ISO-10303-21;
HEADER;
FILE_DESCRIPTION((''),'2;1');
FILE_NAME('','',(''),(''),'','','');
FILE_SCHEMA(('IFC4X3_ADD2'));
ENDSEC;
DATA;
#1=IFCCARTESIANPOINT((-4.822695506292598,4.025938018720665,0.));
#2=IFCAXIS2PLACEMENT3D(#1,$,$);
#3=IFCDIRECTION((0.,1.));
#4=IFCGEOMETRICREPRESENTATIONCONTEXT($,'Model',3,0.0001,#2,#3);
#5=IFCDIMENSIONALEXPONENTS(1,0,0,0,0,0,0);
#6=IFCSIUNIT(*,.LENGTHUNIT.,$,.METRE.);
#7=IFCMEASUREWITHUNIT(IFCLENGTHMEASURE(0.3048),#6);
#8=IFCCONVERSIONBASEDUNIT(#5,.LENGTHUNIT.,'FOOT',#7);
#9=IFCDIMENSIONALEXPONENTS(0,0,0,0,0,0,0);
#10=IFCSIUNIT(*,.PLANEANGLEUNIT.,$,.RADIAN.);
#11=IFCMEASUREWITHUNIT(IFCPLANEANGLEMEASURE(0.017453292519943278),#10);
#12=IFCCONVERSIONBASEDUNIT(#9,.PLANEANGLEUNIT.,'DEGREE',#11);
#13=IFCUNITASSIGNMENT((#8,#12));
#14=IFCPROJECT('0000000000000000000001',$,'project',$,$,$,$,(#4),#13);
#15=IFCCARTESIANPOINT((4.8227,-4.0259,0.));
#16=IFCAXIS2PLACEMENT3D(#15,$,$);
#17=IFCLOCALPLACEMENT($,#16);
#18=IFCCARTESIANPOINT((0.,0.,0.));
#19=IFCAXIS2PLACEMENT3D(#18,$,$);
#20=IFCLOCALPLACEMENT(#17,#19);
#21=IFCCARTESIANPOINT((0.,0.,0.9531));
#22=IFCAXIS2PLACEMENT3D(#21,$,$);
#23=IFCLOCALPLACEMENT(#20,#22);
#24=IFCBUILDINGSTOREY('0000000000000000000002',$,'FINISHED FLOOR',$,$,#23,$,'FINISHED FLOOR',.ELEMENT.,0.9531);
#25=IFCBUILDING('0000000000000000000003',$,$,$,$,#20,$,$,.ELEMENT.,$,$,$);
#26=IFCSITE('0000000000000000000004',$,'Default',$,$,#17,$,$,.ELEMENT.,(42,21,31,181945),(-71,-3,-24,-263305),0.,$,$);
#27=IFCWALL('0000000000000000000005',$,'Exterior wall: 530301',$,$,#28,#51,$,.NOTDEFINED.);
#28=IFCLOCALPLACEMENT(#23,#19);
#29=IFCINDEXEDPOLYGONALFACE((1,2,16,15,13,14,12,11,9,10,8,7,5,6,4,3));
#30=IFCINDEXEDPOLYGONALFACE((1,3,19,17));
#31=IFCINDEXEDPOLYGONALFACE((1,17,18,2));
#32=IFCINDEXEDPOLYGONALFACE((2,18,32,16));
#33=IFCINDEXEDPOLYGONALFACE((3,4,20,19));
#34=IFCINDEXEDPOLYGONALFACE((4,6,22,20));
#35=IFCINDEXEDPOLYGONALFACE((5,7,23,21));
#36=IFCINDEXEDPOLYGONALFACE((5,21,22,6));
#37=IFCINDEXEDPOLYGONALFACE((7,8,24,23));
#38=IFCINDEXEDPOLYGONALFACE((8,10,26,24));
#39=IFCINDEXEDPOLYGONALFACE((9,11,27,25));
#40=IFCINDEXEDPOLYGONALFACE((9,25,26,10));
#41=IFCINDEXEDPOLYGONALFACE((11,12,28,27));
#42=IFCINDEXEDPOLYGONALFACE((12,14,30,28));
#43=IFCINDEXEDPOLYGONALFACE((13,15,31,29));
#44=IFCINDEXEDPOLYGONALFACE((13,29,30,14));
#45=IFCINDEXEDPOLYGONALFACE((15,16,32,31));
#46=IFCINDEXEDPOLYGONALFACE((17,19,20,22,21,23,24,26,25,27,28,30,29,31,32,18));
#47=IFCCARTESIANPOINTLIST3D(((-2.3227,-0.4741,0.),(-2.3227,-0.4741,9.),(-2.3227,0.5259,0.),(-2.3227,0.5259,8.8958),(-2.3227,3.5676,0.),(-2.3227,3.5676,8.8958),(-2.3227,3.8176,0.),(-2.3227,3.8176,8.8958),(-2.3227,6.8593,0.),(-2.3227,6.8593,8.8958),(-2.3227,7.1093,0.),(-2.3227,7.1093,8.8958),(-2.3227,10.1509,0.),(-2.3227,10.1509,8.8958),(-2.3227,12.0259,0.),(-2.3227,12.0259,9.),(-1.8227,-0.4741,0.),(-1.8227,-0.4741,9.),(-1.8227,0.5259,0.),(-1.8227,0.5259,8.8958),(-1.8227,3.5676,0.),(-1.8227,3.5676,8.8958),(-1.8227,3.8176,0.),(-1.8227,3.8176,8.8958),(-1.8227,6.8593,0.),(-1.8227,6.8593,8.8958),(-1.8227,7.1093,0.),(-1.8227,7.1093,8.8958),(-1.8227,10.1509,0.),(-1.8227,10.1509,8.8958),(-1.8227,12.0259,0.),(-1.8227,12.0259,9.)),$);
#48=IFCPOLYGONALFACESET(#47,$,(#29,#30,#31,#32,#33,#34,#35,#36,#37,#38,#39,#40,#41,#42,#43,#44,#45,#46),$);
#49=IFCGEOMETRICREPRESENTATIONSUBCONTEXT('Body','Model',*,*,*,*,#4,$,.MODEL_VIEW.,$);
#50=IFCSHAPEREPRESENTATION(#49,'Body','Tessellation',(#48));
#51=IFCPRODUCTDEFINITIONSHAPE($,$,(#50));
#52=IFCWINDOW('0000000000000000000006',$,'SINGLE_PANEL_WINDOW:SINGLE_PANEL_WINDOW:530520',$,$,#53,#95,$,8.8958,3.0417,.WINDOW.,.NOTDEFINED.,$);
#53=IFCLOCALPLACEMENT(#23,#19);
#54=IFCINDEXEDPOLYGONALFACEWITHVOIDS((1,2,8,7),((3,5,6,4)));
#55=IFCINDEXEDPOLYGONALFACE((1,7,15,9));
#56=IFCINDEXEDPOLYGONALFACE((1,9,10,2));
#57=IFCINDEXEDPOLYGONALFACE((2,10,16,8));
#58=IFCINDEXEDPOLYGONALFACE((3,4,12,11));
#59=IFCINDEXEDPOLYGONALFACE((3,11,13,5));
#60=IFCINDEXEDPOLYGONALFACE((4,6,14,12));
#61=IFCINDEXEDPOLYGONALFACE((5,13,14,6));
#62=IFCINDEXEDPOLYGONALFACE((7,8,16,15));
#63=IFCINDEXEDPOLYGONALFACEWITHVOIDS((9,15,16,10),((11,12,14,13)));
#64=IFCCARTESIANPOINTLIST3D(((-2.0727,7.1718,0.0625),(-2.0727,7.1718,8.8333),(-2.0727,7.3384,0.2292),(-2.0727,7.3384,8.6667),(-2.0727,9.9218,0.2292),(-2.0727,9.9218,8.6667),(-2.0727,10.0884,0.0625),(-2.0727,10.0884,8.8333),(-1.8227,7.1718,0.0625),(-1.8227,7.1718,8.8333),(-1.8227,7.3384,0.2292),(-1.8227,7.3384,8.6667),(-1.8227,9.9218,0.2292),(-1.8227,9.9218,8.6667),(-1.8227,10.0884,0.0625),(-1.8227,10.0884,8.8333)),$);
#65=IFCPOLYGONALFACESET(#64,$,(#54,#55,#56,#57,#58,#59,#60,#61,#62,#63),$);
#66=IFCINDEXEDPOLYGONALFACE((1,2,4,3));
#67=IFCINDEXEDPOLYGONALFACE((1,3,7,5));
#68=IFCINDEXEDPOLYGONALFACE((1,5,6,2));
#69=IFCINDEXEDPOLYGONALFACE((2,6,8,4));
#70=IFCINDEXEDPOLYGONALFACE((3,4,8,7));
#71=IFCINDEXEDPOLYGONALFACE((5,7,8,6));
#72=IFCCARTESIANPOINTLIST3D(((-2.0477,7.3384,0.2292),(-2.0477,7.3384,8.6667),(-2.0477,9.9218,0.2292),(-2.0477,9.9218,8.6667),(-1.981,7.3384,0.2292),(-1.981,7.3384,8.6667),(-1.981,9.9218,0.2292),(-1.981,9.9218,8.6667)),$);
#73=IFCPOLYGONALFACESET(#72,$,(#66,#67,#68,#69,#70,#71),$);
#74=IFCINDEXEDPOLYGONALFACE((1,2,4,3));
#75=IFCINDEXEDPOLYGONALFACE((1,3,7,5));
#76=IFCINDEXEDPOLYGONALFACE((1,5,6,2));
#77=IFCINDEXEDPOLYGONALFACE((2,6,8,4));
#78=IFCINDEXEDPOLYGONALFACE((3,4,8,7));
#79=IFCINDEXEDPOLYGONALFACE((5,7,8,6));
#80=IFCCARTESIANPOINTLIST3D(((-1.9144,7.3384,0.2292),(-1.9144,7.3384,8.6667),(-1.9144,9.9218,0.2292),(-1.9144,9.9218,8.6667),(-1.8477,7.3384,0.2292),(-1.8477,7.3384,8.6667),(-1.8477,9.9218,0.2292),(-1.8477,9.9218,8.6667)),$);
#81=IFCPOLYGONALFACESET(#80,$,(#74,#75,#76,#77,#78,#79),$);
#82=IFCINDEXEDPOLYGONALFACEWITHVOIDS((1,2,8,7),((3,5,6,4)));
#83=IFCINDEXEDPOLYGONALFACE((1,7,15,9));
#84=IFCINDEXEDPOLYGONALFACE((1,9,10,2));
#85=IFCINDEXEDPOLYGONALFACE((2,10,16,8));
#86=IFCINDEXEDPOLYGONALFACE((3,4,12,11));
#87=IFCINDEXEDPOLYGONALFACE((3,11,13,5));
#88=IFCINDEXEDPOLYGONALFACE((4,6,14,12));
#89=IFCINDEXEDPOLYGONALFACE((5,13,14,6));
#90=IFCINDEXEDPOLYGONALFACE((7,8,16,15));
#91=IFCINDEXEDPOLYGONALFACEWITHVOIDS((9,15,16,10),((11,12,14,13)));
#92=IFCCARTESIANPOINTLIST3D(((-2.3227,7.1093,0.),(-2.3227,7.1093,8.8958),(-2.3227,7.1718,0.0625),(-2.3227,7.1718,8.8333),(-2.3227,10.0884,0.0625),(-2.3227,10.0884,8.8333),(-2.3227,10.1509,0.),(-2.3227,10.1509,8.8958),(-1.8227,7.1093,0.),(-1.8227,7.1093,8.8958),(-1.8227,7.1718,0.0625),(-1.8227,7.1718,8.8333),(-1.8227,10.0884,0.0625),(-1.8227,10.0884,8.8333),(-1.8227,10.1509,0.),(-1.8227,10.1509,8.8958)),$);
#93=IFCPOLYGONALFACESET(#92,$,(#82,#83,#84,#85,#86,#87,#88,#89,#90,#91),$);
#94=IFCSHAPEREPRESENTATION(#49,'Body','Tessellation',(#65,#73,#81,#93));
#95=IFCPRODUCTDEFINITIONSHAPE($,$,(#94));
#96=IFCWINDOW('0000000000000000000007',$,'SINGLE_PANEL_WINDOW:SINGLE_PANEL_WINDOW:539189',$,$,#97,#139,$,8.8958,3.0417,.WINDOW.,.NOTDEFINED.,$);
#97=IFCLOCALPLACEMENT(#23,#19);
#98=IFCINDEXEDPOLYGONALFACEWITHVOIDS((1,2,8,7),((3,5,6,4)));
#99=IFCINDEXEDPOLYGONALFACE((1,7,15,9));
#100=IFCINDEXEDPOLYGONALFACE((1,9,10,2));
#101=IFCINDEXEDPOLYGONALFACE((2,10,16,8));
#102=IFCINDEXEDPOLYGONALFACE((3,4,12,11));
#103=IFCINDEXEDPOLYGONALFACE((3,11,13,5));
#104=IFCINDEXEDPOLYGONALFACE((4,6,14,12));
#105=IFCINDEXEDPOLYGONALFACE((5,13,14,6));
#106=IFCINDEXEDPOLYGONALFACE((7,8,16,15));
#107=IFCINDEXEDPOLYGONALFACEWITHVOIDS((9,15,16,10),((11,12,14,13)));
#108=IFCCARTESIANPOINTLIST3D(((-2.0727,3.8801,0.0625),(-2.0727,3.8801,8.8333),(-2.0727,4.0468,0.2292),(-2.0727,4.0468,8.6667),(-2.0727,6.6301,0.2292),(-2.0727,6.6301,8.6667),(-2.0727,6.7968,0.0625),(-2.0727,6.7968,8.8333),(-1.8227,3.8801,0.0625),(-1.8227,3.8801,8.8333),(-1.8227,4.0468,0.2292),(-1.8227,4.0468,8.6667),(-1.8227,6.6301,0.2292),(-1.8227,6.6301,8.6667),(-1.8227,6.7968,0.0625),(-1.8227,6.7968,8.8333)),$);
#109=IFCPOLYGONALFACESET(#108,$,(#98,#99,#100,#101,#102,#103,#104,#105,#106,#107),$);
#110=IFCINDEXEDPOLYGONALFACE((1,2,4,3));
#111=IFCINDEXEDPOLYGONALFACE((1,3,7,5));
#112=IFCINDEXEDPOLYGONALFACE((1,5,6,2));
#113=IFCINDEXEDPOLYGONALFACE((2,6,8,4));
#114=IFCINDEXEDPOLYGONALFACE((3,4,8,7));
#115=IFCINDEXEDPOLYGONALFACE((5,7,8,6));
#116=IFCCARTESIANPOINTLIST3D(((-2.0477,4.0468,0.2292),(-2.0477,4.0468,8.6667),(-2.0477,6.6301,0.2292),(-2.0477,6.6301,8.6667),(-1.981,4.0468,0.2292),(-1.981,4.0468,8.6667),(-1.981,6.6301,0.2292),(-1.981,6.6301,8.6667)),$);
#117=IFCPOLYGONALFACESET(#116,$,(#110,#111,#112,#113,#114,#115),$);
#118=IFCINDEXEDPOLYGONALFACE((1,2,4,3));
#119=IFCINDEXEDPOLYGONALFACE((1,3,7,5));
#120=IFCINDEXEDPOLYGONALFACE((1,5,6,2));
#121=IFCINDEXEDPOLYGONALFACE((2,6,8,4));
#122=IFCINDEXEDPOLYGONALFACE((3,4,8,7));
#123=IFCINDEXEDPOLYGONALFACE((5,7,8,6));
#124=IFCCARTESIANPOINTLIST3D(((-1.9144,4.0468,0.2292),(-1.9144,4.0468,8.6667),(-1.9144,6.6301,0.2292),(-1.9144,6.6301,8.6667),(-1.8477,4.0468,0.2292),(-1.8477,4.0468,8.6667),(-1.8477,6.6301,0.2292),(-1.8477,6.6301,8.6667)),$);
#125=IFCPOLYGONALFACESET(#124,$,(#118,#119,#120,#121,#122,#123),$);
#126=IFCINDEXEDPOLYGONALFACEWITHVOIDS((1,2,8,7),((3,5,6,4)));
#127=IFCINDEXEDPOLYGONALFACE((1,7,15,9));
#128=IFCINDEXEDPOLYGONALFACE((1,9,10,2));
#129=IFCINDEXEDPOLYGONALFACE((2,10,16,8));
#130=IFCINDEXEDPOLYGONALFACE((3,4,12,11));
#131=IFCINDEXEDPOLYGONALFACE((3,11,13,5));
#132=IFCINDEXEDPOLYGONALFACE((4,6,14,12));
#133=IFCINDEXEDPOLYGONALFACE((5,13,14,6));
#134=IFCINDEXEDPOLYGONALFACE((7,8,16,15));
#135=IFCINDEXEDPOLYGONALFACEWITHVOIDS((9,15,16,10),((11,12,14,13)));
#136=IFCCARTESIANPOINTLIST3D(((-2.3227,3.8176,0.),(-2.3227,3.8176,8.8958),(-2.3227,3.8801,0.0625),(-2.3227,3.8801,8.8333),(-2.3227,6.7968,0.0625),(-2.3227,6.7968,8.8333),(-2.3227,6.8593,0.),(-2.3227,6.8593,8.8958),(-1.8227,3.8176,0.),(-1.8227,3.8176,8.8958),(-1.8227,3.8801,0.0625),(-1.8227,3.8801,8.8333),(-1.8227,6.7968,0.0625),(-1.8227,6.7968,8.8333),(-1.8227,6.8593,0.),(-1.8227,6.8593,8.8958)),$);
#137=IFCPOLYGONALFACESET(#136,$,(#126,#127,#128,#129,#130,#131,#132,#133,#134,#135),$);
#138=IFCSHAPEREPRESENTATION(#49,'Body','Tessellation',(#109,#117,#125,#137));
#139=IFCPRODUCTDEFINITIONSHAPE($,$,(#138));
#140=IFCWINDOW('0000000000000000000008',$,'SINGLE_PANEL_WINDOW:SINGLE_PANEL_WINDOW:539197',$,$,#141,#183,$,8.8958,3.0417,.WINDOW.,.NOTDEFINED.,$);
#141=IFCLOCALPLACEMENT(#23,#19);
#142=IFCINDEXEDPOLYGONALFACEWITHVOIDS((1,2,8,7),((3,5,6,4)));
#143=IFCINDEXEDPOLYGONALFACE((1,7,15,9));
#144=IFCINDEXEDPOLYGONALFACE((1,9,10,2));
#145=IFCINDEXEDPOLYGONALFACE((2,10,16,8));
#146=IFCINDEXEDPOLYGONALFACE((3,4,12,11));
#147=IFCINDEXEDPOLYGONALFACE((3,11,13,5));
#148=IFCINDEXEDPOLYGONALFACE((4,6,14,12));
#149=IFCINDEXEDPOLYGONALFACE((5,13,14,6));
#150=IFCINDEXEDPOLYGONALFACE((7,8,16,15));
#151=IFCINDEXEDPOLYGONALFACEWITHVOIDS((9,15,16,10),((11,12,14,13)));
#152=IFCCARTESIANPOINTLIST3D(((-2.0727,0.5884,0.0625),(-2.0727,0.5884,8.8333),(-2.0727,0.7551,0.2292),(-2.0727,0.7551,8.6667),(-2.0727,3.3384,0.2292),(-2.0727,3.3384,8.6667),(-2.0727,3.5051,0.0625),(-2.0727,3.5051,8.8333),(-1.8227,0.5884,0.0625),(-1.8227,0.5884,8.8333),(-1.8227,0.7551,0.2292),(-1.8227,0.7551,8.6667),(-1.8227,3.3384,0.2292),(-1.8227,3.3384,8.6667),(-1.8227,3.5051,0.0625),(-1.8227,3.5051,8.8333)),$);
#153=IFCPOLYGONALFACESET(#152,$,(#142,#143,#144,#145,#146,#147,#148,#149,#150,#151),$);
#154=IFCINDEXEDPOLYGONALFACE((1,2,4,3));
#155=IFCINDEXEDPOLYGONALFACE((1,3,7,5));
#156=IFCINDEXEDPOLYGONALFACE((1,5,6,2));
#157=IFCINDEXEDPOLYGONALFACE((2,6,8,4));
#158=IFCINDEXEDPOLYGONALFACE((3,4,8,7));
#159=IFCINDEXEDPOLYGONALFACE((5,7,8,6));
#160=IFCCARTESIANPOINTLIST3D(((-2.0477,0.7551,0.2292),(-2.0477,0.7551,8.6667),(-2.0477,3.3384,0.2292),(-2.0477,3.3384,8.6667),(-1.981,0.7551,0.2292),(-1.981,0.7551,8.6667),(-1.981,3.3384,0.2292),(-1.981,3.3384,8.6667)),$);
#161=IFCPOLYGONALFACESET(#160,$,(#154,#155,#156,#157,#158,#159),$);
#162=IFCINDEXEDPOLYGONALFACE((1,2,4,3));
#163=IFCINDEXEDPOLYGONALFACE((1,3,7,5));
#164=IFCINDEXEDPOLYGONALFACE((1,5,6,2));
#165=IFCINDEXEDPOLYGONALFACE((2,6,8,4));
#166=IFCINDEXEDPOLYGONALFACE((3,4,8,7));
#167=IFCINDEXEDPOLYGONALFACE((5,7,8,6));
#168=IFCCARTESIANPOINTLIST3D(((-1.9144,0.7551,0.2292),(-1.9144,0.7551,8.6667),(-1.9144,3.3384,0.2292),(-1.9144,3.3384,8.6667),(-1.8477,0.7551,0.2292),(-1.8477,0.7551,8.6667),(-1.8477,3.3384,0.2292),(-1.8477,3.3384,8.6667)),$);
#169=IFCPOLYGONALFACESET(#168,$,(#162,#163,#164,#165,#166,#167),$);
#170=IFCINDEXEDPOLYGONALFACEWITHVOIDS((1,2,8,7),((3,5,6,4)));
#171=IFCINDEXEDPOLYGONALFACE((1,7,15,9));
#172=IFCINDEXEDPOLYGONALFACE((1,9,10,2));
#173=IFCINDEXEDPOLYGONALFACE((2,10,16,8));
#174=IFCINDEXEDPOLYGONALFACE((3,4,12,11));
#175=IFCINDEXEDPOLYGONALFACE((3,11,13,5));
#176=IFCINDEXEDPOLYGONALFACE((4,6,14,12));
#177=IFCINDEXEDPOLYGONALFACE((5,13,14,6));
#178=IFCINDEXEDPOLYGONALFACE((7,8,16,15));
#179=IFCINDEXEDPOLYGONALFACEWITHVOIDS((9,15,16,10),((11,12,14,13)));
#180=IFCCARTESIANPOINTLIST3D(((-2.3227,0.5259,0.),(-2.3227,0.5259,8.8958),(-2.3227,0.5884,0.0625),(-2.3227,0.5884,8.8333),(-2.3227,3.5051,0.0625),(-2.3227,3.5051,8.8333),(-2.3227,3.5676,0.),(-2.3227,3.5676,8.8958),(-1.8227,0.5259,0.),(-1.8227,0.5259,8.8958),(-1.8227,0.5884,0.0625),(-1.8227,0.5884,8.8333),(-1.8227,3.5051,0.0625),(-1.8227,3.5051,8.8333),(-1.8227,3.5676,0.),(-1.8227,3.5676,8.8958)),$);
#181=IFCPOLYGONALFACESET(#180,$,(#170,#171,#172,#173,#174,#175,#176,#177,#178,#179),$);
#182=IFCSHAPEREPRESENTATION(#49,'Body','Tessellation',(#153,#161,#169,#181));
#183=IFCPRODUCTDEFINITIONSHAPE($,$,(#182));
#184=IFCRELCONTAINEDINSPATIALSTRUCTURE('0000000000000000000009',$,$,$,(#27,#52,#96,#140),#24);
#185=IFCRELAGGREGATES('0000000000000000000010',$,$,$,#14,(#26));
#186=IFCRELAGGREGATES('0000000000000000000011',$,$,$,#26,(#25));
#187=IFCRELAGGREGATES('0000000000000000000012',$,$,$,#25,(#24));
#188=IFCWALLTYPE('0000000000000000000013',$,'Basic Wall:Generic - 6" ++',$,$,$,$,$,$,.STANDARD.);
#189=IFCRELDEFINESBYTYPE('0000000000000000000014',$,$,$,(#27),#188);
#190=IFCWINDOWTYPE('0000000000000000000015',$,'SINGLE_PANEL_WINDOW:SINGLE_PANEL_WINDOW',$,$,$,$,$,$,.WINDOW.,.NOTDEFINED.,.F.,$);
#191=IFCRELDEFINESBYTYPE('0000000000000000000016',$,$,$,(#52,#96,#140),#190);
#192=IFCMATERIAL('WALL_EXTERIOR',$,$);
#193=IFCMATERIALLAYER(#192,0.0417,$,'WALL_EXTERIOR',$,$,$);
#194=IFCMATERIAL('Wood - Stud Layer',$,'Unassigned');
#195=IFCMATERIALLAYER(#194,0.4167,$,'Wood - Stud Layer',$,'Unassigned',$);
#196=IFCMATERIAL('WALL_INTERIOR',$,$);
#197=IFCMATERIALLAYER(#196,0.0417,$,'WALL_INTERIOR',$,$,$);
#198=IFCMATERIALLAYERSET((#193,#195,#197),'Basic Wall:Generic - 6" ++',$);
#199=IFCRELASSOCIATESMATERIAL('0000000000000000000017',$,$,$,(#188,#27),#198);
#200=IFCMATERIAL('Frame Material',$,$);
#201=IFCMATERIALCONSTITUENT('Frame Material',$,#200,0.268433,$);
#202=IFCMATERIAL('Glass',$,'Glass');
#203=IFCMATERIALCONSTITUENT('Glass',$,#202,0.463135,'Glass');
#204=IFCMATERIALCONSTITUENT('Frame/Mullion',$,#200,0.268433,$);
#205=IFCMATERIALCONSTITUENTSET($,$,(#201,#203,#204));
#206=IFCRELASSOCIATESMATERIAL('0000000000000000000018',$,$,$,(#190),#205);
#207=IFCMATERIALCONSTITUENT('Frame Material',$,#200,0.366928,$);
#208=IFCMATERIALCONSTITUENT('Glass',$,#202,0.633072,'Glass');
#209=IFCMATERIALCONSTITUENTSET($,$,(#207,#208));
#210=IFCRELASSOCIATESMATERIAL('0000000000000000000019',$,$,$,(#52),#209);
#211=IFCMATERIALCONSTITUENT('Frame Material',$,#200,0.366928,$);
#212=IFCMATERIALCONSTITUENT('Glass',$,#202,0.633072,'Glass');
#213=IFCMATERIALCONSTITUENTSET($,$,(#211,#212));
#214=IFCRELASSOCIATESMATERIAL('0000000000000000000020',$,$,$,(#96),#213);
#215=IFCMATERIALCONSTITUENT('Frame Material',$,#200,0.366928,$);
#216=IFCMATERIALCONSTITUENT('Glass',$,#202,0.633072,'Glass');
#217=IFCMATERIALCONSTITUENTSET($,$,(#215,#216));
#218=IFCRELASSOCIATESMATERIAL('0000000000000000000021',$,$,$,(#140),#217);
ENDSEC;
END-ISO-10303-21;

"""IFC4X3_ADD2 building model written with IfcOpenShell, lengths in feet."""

from ifc_helpers import new_model, entity, si_unit, converted_unit, direction, frame, frame_2d, origin, origin_2d_with_axis, place, context, subcontext, project, spatial, polyline, rectangle, outline, extrude, source, transform, mapped, material, layer, layer_set, constituent, constituent_set, type_object, type_shapes, element, fill, save


model = new_model("IFC4X3_ADD2")

# Units and contexts
model_context = context("Model", 3, precision=0.0001, world=frame((-4.822695506292598, 4.025938018720665, 0.0)), true_north=direction((0.0, 1.0)))
body_context = subcontext(model_context, "Body", "Model", "MODEL_VIEW")
ifc_project = project(units=[converted_unit("LENGTHUNIT", "FOOT", entity("IfcLengthMeasure", 0.3048), si_unit("LENGTHUNIT", "METRE"), dimensions=[1, 0, 0, 0, 0, 0, 0]), converted_unit("PLANEANGLEUNIT", "DEGREE", entity("IfcPlaneAngleMeasure", 0.017453292519943278), si_unit("PLANEANGLEUNIT", "RADIAN"), dimensions=[0, 0, 0, 0, 0, 0, 0])], contexts=[model_context])

# Site, building, storey
site_placement = place(None, frame((4.8227, -4.0259, 0.0)))
site = spatial("IfcSite", under=ifc_project, at=site_placement, Name="Default", CompositionType="ELEMENT", RefLatitude=(42, 21, 31, 181945), RefLongitude=(-71, -3, -24, -263305), RefElevation=0.0)
building_placement = place(site_placement, origin())
building = spatial("IfcBuilding", under=site, at=building_placement, CompositionType="ELEMENT")
storey_placement = place(building_placement, frame((0.0, 0.0, 0.9531)))
storey = spatial("IfcBuildingStorey", under=building, at=storey_placement, Name="FINISHED FLOOR", LongName="FINISHED FLOOR", CompositionType="ELEMENT", Elevation=0.9531)

# Shared definitions
ifc_material_1 = material(Name="WALL_EXTERIOR")
ifc_layer_1 = layer(ifc_material_1, 0.0417, Name="WALL_EXTERIOR")
ifc_material_2 = material(Name="Wood - Stud Layer", Category="Unassigned")
ifc_layer_2 = layer(ifc_material_2, 0.4167, Name="Wood - Stud Layer", Category="Unassigned")
ifc_material_3 = material(Name="WALL_INTERIOR")
ifc_layer_3 = layer(ifc_material_3, 0.0417, Name="WALL_INTERIOR")
ifc_layer_set_1 = layer_set([ifc_layer_1, ifc_layer_2, ifc_layer_3], Name="Basic Wall:Generic - 6\" ++")
wall_type_1 = type_object("IfcWallType", Name="Basic Wall:Generic - 6\" ++", PredefinedType="STANDARD", material=ifc_layer_set_1)
ifc_material_4 = material(Name="Frame Material")
ifc_material_5 = material(Name="Glass", Category="Glass")

# Wall, openings, windows
wall_1_placement = place(storey_placement, frame((-2.0727, 12.0259, 0.0), z_axis=(0.0, 0.0, 1.0), x_axis=(0.0, -1.0, 0.0)))
wall_1 = element("IfcWall", 1, at=wall_1_placement, inside=storey, type_object=wall_type_1, material=ifc_layer_set_1, Name="Exterior wall: 530301", PredefinedType="NOTDEFINED", context=body_context, shape_type="SweptSolid", body=[
    extrude(rectangle(XDim=12.5, YDim=0.5, at=frame_2d((6.25, 0.0))), origin(), (0.0, 0.0, 1.0), 9.0),
])
opening_1_placement = place(wall_1_placement, frame((1.875, -0.25, 0.0)))
opening_1 = element("IfcOpeningElement", 2, at=opening_1_placement, cuts=wall_1, PredefinedType="OPENING", context=body_context, shape_type="SweptSolid", body=[
    extrude(rectangle(XDim=8.8958, YDim=3.0417, at=frame_2d((4.4479, 1.5208), x_axis=(-1.0, 0.0))), frame((0.0, 0.0, 0.0), z_axis=(0.0, 1.0, 0.0), x_axis=(0.0, 0.0, 1.0)), (0.0, 0.0, 1.0), 0.5),
])
opening_2_placement = place(wall_1_placement, frame((5.1667, -0.25, 0.0)))
opening_2 = element("IfcOpeningElement", 3, at=opening_2_placement, cuts=wall_1, PredefinedType="OPENING", context=body_context, shape_type="SweptSolid", body=[
    extrude(rectangle(XDim=8.8958, YDim=3.0417, at=frame_2d((4.4479, 1.5208), x_axis=(-1.0, 0.0))), frame((0.0, 0.0, 0.0), z_axis=(0.0, 1.0, 0.0), x_axis=(0.0, 0.0, 1.0)), (0.0, 0.0, 1.0), 0.5),
])
opening_3_placement = place(wall_1_placement, frame((8.4583, -0.25, 0.0)))
opening_3 = element("IfcOpeningElement", 4, at=opening_3_placement, cuts=wall_1, PredefinedType="OPENING", context=body_context, shape_type="SweptSolid", body=[
    extrude(rectangle(XDim=8.8958, YDim=3.0417, at=frame_2d((4.4479, 1.5208), x_axis=(-1.0, 0.0))), frame((0.0, 0.0, 0.0), z_axis=(0.0, 1.0, 0.0), x_axis=(0.0, 0.0, 1.0)), (0.0, 0.0, 1.0), 0.5),
])
ifc_constituent_1 = constituent(ifc_material_4, Name="Frame Material", fraction=0.366928)
ifc_constituent_2 = constituent(ifc_material_5, Name="Glass", Category="Glass", fraction=0.633072)
ifc_constituent_set_1 = constituent_set(constituents=[ifc_constituent_1, ifc_constituent_2])
ifc_constituent_3 = constituent(ifc_material_4, Name="Frame Material", fraction=0.268433)
ifc_constituent_4 = constituent(ifc_material_5, Name="Glass", Category="Glass", fraction=0.463135)
ifc_constituent_5 = constituent(ifc_material_4, Name="Frame/Mullion", fraction=0.268433)
ifc_constituent_set_2 = constituent_set(constituents=[ifc_constituent_3, ifc_constituent_4, ifc_constituent_5])
window_type_1 = type_object("IfcWindowType", Name="SINGLE_PANEL_WINDOW:SINGLE_PANEL_WINDOW", ParameterTakesPrecedence=False, PartitioningType="NOTDEFINED", PredefinedType="WINDOW", material=ifc_constituent_set_2)
shared_shape_1 = source(origin(), body_context, "Body", "SweptSolid", [
    extrude(outline(polyline([(-1.4583, -4.3854), (1.4583, -4.3854), (1.4583, 4.3854), (-1.4583, 4.3854), (-1.4583, -4.3854)]), holes=[polyline([(1.2917, 4.2187), (1.2917, -4.2188), (-1.2917, -4.2188), (-1.2917, 4.2187), (1.2917, 4.2187)])]), frame((1.5208, 0.5, 4.4479), z_axis=(0.0, -1.0, 0.0), x_axis=(-1.0, 0.0, 0.0)), (0.0, 0.0, 1.0), 0.25),
    extrude(rectangle(XDim=2.5833, YDim=0.0667, at=origin_2d_with_axis()), frame((1.5208, 0.3083, 0.2292), z_axis=(0.0, 0.0, 1.0), x_axis=(-1.0, 0.0, 0.0)), (0.0, 0.0, 1.0), 8.4375),
    extrude(rectangle(XDim=2.5833, YDim=0.0667, at=frame_2d((0.0, 0.0), x_axis=(1.0, 0.0))), frame((1.5208, 0.4417, 0.2292), z_axis=(0.0, 0.0, 1.0), x_axis=(-1.0, 0.0, 0.0)), (0.0, 0.0, 1.0), 8.4375),
    extrude(outline(polyline([(-4.4479, -1.5208), (4.4479, -1.5208), (4.4479, 1.5208), (-4.4479, 1.5208), (-4.4479, -1.5208)]), holes=[polyline([(-4.3854, -1.4583), (-4.3854, 1.4583), (4.3854, 1.4583), (4.3854, -1.4583), (-4.3854, -1.4583)])]), frame((1.5208, 0.5, 4.4479), z_axis=(0.0, -1.0, 0.0), x_axis=(0.0, 0.0, -1.0)), (0.0, 0.0, 1.0), 0.5),
])
type_shapes(window_type_1, [shared_shape_1])
window_1_placement = place(opening_1_placement, origin())
window_1 = element("IfcWindow", 5, at=window_1_placement, inside=storey, type_object=window_type_1, material=ifc_constituent_set_1, Name="SINGLE_PANEL_WINDOW:SINGLE_PANEL_WINDOW:530520", OverallHeight=8.8958, OverallWidth=3.0417, PartitioningType="NOTDEFINED", PredefinedType="WINDOW", context=body_context, shape_type="MappedRepresentation", body=[
    mapped(shared_shape_1, transform((0.0, 0.0, 0.0), scale=1.0)),
])
fill(opening_1, window_1)
ifc_constituent_6 = constituent(ifc_material_4, Name="Frame Material", fraction=0.366928)
ifc_constituent_7 = constituent(ifc_material_5, Name="Glass", Category="Glass", fraction=0.633072)
ifc_constituent_set_3 = constituent_set(constituents=[ifc_constituent_6, ifc_constituent_7])
window_2_placement = place(opening_2_placement, origin())
window_2 = element("IfcWindow", 6, at=window_2_placement, inside=storey, type_object=window_type_1, material=ifc_constituent_set_3, Name="SINGLE_PANEL_WINDOW:SINGLE_PANEL_WINDOW:539189", OverallHeight=8.8958, OverallWidth=3.0417, PartitioningType="NOTDEFINED", PredefinedType="WINDOW", context=body_context, shape_type="MappedRepresentation", body=[
    mapped(shared_shape_1, transform((0.0, 0.0, 0.0), scale=1.0)),
])
fill(opening_2, window_2)
ifc_constituent_8 = constituent(ifc_material_4, Name="Frame Material", fraction=0.366928)
ifc_constituent_9 = constituent(ifc_material_5, Name="Glass", Category="Glass", fraction=0.633072)
ifc_constituent_set_4 = constituent_set(constituents=[ifc_constituent_8, ifc_constituent_9])
window_3_placement = place(opening_3_placement, origin())
window_3 = element("IfcWindow", 7, at=window_3_placement, inside=storey, type_object=window_type_1, material=ifc_constituent_set_4, Name="SINGLE_PANEL_WINDOW:SINGLE_PANEL_WINDOW:539197", OverallHeight=8.8958, OverallWidth=3.0417, PartitioningType="NOTDEFINED", PredefinedType="WINDOW", context=body_context, shape_type="MappedRepresentation", body=[
    mapped(shared_shape_1, transform((0.0, 0.0, 0.0), scale=1.0)),
])
fill(opening_3, window_3)

save(model, "model.ifc")
